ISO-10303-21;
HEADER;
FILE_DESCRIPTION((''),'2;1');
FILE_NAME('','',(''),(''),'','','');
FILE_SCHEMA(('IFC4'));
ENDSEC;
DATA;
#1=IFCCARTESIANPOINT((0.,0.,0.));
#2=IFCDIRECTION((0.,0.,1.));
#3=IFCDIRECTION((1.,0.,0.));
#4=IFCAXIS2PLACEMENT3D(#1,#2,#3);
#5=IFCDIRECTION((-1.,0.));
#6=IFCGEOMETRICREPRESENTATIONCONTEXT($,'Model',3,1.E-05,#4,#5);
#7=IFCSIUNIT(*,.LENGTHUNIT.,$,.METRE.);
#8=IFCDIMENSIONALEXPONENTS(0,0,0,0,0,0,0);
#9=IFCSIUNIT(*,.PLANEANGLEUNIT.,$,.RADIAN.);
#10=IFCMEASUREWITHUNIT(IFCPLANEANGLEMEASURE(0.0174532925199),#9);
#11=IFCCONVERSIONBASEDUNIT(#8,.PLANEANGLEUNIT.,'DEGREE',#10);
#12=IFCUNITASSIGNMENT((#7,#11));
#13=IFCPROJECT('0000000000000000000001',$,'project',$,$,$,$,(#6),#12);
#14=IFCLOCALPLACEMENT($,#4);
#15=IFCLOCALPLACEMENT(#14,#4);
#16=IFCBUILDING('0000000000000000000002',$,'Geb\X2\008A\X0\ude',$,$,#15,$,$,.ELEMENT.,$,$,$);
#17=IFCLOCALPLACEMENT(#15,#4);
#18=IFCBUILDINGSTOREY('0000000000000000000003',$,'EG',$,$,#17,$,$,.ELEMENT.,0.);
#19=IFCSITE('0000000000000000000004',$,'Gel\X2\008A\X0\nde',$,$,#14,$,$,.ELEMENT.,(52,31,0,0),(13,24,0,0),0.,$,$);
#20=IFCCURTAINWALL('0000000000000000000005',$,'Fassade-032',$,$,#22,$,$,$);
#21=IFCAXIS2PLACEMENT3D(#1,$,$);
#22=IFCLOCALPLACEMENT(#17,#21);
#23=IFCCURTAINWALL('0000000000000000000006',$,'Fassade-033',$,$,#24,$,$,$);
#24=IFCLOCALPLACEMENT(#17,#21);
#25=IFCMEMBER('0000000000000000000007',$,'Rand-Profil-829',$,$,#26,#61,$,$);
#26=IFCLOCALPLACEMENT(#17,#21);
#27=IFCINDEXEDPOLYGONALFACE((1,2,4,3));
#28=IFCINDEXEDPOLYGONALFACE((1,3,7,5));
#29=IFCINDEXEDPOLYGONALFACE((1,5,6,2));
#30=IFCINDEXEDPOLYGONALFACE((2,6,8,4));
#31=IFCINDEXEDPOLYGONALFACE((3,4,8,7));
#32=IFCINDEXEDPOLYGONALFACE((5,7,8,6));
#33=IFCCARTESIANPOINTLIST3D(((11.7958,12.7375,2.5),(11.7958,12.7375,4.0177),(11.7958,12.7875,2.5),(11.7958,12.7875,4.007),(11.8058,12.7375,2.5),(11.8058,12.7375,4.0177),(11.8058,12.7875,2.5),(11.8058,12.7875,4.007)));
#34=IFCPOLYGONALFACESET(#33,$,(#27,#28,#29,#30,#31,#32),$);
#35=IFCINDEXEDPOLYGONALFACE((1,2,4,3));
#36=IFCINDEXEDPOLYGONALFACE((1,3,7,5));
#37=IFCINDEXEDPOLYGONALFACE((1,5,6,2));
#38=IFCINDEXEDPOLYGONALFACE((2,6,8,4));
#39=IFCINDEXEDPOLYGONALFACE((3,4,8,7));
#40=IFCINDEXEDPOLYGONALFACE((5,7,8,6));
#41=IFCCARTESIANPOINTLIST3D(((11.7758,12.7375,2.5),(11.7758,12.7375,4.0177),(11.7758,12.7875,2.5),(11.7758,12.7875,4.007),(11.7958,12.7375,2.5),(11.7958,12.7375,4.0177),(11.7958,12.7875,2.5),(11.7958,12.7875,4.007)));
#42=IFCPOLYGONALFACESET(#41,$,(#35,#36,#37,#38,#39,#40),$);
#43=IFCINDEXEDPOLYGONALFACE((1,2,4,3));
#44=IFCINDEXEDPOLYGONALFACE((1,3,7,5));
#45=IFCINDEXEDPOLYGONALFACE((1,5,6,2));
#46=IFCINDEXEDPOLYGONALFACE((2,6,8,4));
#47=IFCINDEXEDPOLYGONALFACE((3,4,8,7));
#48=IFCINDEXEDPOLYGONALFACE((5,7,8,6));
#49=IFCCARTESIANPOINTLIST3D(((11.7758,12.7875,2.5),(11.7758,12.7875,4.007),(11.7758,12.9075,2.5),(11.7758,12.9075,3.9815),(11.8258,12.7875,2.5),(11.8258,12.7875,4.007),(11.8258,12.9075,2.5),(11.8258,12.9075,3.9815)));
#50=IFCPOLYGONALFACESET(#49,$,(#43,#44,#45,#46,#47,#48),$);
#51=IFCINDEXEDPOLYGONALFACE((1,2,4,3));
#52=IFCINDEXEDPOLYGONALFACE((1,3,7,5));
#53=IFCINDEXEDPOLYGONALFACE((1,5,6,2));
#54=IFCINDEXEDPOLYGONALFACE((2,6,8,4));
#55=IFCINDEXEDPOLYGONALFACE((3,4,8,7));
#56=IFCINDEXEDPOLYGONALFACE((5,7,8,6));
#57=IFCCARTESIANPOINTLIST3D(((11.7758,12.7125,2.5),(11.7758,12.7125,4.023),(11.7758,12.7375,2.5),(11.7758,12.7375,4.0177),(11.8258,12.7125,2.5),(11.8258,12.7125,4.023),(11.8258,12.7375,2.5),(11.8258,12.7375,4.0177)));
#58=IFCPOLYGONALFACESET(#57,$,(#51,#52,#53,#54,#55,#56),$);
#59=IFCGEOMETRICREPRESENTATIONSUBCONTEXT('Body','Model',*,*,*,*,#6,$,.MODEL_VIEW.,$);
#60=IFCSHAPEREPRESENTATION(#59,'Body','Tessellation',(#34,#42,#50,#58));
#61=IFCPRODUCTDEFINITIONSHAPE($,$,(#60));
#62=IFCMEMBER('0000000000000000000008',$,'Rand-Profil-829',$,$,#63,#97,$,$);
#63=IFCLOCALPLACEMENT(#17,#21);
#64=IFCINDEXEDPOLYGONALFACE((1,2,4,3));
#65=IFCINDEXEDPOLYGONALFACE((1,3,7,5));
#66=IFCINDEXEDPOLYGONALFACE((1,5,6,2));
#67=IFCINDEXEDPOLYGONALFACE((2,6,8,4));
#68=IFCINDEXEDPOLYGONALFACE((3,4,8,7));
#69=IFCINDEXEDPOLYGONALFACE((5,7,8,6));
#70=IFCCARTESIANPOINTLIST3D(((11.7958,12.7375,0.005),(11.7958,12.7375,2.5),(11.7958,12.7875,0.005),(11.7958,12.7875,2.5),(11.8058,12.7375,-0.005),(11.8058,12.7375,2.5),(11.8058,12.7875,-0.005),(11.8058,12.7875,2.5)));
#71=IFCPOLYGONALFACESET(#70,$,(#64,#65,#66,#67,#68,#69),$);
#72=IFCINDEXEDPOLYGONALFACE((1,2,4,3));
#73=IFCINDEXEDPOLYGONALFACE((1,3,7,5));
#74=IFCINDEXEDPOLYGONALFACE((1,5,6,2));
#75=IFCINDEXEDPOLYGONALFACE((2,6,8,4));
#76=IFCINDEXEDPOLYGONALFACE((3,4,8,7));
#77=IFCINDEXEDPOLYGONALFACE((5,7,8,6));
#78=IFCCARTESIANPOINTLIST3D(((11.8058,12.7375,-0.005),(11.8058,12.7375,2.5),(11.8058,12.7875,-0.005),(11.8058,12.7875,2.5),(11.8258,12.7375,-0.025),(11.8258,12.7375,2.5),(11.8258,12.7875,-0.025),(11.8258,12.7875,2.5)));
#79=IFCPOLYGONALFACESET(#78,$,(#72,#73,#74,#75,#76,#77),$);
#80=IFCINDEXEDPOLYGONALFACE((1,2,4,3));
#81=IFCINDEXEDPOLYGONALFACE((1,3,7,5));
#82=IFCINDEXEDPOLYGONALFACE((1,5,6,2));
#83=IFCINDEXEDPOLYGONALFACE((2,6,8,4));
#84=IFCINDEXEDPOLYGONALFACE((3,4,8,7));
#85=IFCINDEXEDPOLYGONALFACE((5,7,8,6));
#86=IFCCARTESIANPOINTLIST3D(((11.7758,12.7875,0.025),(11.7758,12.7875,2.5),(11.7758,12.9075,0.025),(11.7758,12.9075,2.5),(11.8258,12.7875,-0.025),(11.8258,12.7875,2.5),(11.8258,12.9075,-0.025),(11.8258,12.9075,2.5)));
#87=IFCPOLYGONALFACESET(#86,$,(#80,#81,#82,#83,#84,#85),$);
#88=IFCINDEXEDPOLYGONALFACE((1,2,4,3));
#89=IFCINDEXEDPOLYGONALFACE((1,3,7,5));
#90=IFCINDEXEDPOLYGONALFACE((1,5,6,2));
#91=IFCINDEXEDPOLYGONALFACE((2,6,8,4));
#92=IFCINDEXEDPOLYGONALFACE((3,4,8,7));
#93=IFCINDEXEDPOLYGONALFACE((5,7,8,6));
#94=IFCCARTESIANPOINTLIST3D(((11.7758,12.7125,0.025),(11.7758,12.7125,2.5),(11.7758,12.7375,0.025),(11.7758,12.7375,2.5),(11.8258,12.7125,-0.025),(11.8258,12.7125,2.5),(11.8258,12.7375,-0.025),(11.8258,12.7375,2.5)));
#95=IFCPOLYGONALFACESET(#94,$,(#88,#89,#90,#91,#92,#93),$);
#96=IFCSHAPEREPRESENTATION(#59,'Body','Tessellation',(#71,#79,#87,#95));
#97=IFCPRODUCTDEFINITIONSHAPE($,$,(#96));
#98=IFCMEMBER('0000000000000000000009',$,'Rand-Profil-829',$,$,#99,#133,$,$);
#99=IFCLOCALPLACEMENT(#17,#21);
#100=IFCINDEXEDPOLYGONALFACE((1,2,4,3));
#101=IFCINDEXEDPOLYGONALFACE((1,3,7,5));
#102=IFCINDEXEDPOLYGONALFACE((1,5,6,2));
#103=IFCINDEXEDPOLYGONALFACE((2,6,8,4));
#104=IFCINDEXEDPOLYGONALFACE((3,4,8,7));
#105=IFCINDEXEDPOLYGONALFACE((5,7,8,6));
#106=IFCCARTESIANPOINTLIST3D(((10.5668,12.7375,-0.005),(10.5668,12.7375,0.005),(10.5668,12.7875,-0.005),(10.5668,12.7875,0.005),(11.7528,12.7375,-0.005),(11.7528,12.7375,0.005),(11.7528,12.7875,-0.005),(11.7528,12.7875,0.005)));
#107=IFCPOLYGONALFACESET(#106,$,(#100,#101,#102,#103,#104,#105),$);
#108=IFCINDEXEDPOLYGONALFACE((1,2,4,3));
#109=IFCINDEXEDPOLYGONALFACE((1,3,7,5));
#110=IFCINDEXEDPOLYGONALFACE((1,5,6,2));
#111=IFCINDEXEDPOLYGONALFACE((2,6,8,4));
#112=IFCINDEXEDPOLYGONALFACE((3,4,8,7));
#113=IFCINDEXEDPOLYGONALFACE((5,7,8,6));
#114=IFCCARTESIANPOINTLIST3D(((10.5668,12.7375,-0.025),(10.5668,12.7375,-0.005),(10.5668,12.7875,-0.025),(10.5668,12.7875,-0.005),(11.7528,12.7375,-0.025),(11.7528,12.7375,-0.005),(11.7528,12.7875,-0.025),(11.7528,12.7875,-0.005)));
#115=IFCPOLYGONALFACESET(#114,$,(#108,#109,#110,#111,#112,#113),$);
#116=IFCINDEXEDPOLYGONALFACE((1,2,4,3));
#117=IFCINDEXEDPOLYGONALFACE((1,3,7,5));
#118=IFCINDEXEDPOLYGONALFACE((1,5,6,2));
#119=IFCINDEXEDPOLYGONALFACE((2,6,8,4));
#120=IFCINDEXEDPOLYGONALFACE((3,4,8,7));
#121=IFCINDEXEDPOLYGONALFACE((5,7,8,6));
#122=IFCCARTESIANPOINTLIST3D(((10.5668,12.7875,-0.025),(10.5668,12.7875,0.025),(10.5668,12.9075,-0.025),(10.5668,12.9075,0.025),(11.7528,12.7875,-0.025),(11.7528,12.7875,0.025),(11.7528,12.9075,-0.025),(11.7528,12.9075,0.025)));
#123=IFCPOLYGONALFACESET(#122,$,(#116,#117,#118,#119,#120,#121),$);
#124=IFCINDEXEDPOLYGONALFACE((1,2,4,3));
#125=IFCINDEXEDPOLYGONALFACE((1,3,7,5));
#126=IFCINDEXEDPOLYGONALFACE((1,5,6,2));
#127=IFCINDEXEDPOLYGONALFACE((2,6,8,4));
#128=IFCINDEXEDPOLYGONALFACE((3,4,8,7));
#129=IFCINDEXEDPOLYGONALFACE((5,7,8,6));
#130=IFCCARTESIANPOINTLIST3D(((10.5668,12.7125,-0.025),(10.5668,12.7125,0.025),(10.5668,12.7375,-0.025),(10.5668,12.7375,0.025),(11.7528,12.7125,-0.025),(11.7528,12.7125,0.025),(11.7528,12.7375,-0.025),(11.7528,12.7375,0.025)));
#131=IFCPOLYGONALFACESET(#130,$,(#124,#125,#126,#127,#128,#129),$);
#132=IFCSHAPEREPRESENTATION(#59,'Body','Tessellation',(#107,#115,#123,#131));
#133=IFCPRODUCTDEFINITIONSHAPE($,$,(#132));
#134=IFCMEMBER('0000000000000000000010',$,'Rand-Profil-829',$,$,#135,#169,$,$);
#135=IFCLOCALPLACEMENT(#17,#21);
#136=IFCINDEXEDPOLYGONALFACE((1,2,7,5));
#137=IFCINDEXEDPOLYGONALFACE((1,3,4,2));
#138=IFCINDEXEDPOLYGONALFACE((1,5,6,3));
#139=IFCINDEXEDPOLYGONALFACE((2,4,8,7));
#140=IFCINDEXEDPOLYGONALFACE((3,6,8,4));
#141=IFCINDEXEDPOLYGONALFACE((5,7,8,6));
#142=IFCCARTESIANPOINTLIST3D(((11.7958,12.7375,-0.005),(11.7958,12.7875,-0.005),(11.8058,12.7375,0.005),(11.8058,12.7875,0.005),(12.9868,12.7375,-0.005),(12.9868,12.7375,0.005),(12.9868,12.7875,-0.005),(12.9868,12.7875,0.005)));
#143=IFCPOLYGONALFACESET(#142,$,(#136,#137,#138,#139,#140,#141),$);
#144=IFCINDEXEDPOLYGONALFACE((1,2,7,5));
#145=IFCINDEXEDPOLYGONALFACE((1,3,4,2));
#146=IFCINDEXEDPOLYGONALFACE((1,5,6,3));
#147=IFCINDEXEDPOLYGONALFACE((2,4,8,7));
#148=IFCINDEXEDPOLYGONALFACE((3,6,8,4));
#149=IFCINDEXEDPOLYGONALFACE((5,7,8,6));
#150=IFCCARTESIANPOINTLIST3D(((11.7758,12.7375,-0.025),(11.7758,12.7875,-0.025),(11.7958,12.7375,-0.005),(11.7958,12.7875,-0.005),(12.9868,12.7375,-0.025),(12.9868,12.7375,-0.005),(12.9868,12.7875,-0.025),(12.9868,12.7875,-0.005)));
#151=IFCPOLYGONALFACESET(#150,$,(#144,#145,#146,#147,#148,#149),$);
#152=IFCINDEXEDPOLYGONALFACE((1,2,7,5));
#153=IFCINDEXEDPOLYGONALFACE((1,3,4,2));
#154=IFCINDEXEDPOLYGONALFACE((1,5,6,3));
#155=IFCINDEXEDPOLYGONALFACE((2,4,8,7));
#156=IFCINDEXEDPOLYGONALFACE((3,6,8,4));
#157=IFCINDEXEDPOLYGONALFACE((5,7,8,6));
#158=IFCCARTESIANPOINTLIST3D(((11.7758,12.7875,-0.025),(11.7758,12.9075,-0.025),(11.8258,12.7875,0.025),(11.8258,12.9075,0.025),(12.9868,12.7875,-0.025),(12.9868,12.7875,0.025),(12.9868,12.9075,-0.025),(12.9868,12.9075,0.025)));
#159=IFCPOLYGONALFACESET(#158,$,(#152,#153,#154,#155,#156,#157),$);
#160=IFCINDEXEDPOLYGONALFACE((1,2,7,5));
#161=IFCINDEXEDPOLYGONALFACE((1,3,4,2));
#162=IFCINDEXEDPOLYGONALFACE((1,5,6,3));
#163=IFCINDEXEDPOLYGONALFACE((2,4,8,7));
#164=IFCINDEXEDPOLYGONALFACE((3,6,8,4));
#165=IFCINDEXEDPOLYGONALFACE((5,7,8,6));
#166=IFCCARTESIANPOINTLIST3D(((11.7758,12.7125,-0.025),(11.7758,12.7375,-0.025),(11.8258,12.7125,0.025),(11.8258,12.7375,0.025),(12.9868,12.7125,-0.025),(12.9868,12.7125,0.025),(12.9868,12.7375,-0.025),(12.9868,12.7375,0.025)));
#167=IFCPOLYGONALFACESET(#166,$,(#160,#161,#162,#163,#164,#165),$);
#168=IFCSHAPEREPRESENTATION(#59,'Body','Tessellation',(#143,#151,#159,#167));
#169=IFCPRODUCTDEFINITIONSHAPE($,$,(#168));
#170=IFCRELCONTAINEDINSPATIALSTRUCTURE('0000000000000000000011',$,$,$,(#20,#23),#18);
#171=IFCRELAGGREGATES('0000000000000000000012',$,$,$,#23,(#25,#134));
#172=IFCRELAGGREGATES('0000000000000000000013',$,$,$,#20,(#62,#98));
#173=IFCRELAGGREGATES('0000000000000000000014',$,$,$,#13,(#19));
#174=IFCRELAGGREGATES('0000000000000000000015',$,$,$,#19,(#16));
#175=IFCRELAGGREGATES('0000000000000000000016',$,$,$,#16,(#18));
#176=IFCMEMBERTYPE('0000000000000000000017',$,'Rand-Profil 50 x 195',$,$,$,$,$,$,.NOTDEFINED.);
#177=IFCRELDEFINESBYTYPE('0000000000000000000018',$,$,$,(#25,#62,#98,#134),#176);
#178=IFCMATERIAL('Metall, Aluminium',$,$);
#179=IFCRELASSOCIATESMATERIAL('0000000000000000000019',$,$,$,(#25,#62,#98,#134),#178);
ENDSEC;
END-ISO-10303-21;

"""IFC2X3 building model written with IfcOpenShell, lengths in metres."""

from ifc_helpers import new_model, entity, si_unit, converted_unit, direction, frame, origin_with_axes, place, context, subcontext, project, spatial, polyline, outline, extrude, clip, halfspace, material, type_object, element, aggregate, save


model = new_model("IFC2X3")

# Units and contexts
model_context = context("Model", 3, precision=1e-05, world=origin_with_axes(), true_north=direction((-1.0, 0.0)))
body_context = subcontext(model_context, "Body", "Model", "MODEL_VIEW")
ifc_project = project(units=[si_unit("LENGTHUNIT", "METRE"), converted_unit("PLANEANGLEUNIT", "DEGREE", entity("IfcPlaneAngleMeasure", 0.0174532925199), si_unit("PLANEANGLEUNIT", "RADIAN"), dimensions=[0, 0, 0, 0, 0, 0, 0])], contexts=[model_context])

# Site, building, storey
site_placement = place(None, origin_with_axes())
site = spatial("IfcSite", under=ifc_project, at=site_placement, Name="Gel\u008ande", CompositionType="ELEMENT", RefLatitude=(52, 31, 0, 0), RefLongitude=(13, 24, 0, 0), RefElevation=0.0)
building_placement = place(site_placement, origin_with_axes())
building = spatial("IfcBuilding", under=site, at=building_placement, Name="Geb\u008aude", CompositionType="ELEMENT")
storey_placement = place(building_placement, origin_with_axes())
storey = spatial("IfcBuildingStorey", under=building, at=storey_placement, Name="EG", CompositionType="ELEMENT", Elevation=0.0)

# Curtain wall
curtain_wall_1_placement = place(storey_placement, frame((9.9738, 12.7625, 0.0), z_axis=(0.0, 0.0, 1.0), x_axis=(1.0, 0.0, 0.0)))
curtain_wall_1 = element("IfcCurtainWall", 1, at=curtain_wall_1_placement, inside=storey, Name="Fassade-032")
ifc_material = material(Name="Metall, Aluminium")

# Curtain wall
curtain_wall_2_placement = place(storey_placement, frame((12.3938, 12.7625, 0.0), z_axis=(0.0, 0.0, 1.0), x_axis=(1.0, 0.0, 0.0)))
curtain_wall_2 = element("IfcCurtainWall", 2, at=curtain_wall_2_placement, inside=storey, Name="Fassade-033")

# Members
member_type_1 = type_object("IfcMemberType", Name="Rand-Profil 50 x 195", PredefinedType="NOTDEFINED")
member_1_placement = place(curtain_wall_2_placement, frame((-0.593, 0.0, 2.5), z_axis=(0.0, 0.0, 1.0), x_axis=(-1.0, 0.0, 0.0)))
member_1 = element("IfcMember", 3, at=member_1_placement, type_object=member_type_1, material=ifc_material, Name="Rand-Profil-829", context=body_context, shape_type="Clipping", body=[
    clip(extrude(outline(polyline([(0.005, 0.025), (-0.005, 0.025), (-0.005, -0.025), (0.005, -0.025), (0.005, 0.025)])), frame((0.0, 0.0, 0.0), z_axis=(0.0, 0.0, 1.0), x_axis=(-1.0, 0.0, 0.0)), (0.0, 0.0, 1.0), 1.5177), halfspace(frame((0.0, -0.3076, 1.447), z_axis=(0.0, 0.207912, -0.978148), x_axis=(0.0, -0.978148, -0.207912)), True)),
    clip(extrude(outline(polyline([(-0.005, 0.025), (-0.025, 0.025), (-0.025, -0.025), (-0.005, -0.025), (-0.005, 0.025)])), frame((0.0, 0.0, 0.0), z_axis=(0.0, 0.0, 1.0), x_axis=(-1.0, 0.0, 0.0)), (0.0, 0.0, 1.0), 1.5177), halfspace(frame((0.0, -0.3076, 1.447), z_axis=(0.0, 0.207912, -0.978148), x_axis=(0.0, -0.978148, -0.207912)), True)),
    clip(extrude(outline(polyline([(0.025, 0.145), (-0.025, 0.145), (-0.025, 0.025), (0.025, 0.025), (0.025, 0.145)])), frame((0.0, 0.0, 0.0), z_axis=(0.0, 0.0, 1.0), x_axis=(-1.0, 0.0, 0.0)), (0.0, 0.0, 1.0), 1.507), halfspace(frame((0.0, -0.3076, 1.447), z_axis=(0.0, 0.207912, -0.978148), x_axis=(0.0, -0.978148, -0.207912)), True)),
    clip(extrude(outline(polyline([(0.025, -0.025), (-0.025, -0.025), (-0.025, -0.05), (0.025, -0.05), (0.025, -0.025)])), frame((0.0, 0.0, 0.0), z_axis=(0.0, 0.0, 1.0), x_axis=(-1.0, 0.0, 0.0)), (0.0, 0.0, 1.0), 1.523), halfspace(frame((0.0, -0.3076, 1.447), z_axis=(0.0, 0.207912, -0.978148), x_axis=(0.0, -0.978148, -0.207912)), True)),
])
member_2_placement = place(curtain_wall_1_placement, frame((1.827, 0.0, 0.0), z_axis=(0.0, 0.0, 1.0), x_axis=(-1.0, 0.0, 0.0)))
member_2 = element("IfcMember", 4, at=member_2_placement, type_object=member_type_1, material=ifc_material, Name="Rand-Profil-829", context=body_context, shape_type="Clipping", body=[
    clip(extrude(outline(polyline([(-0.005, 0.025), (-0.005, -0.025), (0.005, -0.025), (0.005, 0.025), (-0.005, 0.025)])), frame((0.0, 0.0, -0.005), z_axis=(0.0, 0.0, 1.0), x_axis=(-1.0, 0.0, 0.0)), (0.0, 0.0, 1.0), 2.505), halfspace(frame((0.0, 0.0, 0.0), z_axis=(-0.707107, 0.0, 0.707107), x_axis=(-0.707107, 0.0, -0.707107)), True)),
    clip(extrude(outline(polyline([(0.005, 0.025), (0.005, -0.025), (0.025, -0.025), (0.025, 0.025), (0.005, 0.025)])), frame((0.0, 0.0, -0.025), z_axis=(0.0, 0.0, 1.0), x_axis=(-1.0, 0.0, 0.0)), (0.0, 0.0, 1.0), 2.525), halfspace(frame((0.0, 0.0, 0.0), z_axis=(-0.707107, 0.0, 0.707107), x_axis=(-0.707107, 0.0, -0.707107)), True)),
    clip(extrude(outline(polyline([(-0.025, 0.145), (-0.025, 0.025), (0.025, 0.025), (0.025, 0.145), (-0.025, 0.145)])), frame((0.0, 0.0, -0.025), z_axis=(0.0, 0.0, 1.0), x_axis=(-1.0, 0.0, 0.0)), (0.0, 0.0, 1.0), 2.525), halfspace(frame((0.0, 0.0, 0.0), z_axis=(-0.707107, 0.0, 0.707107), x_axis=(-0.707107, 0.0, -0.707107)), True)),
    clip(extrude(outline(polyline([(0.025, -0.05), (0.025, -0.025), (-0.025, -0.025), (-0.025, -0.05), (0.025, -0.05)])), frame((0.0, 0.0, -0.025), z_axis=(0.0, 0.0, 1.0), x_axis=(-1.0, 0.0, 0.0)), (0.0, 0.0, 1.0), 2.525), halfspace(frame((0.0, 0.0, 0.0), z_axis=(-0.707107, 0.0, 0.707107), x_axis=(-0.707107, 0.0, -0.707107)), True)),
])
member_3_placement = place(curtain_wall_1_placement, frame((0.593, 0.0, 0.0), z_axis=(1.0, 0.0, 0.0), x_axis=(0.0, 0.0, 1.0)))
member_3 = element("IfcMember", 5, at=member_3_placement, type_object=member_type_1, material=ifc_material, Name="Rand-Profil-829", context=body_context, shape_type="SweptSolid", body=[
    extrude(outline(polyline([(-0.025, -0.005), (0.025, -0.005), (0.025, 0.005), (-0.025, 0.005), (-0.025, -0.005)])), frame((0.0, 0.0, 0.0), z_axis=(0.0, 0.0, 1.0), x_axis=(0.0, 1.0, 0.0)), (0.0, 0.0, 1.0), 1.186),
    extrude(outline(polyline([(-0.025, 0.005), (0.025, 0.005), (0.025, 0.025), (-0.025, 0.025), (-0.025, 0.005)])), frame((0.0, 0.0, 0.0), z_axis=(0.0, 0.0, 1.0), x_axis=(0.0, 1.0, 0.0)), (0.0, 0.0, 1.0), 1.186),
    extrude(outline(polyline([(-0.145, -0.025), (-0.025, -0.025), (-0.025, 0.025), (-0.145, 0.025), (-0.145, -0.025)])), frame((0.0, 0.0, 0.0), z_axis=(0.0, 0.0, 1.0), x_axis=(0.0, 1.0, 0.0)), (0.0, 0.0, 1.0), 1.186),
    extrude(outline(polyline([(0.05, 0.025), (0.025, 0.025), (0.025, -0.025), (0.05, -0.025), (0.05, 0.025)])), frame((0.0, 0.0, 0.0), z_axis=(0.0, 0.0, 1.0), x_axis=(0.0, 1.0, 0.0)), (0.0, 0.0, 1.0), 1.186),
])
member_4_placement = place(curtain_wall_2_placement, frame((-0.593, 0.0, 0.0), z_axis=(1.0, 0.0, 0.0), x_axis=(0.0, 0.0, 1.0)))
member_4 = element("IfcMember", 6, at=member_4_placement, type_object=member_type_1, material=ifc_material, Name="Rand-Profil-829", context=body_context, shape_type="Clipping", body=[
    clip(extrude(outline(polyline([(-0.025, -0.005), (0.025, -0.005), (0.025, 0.005), (-0.025, 0.005), (-0.025, -0.005)])), frame((0.0, 0.0, -0.005), z_axis=(0.0, 0.0, 1.0), x_axis=(0.0, 1.0, 0.0)), (0.0, 0.0, 1.0), 1.191), halfspace(frame((0.0, 0.0, 0.0), z_axis=(-0.707107, 0.0, 0.707107), x_axis=(-0.707107, 0.0, -0.707107)), True)),
    clip(extrude(outline(polyline([(-0.025, 0.005), (0.025, 0.005), (0.025, 0.025), (-0.025, 0.025), (-0.025, 0.005)])), frame((0.0, 0.0, -0.025), z_axis=(0.0, 0.0, 1.0), x_axis=(0.0, 1.0, 0.0)), (0.0, 0.0, 1.0), 1.211), halfspace(frame((0.0, 0.0, 0.0), z_axis=(-0.707107, 0.0, 0.707107), x_axis=(-0.707107, 0.0, -0.707107)), True)),
    clip(extrude(outline(polyline([(-0.145, -0.025), (-0.025, -0.025), (-0.025, 0.025), (-0.145, 0.025), (-0.145, -0.025)])), frame((0.0, 0.0, -0.025), z_axis=(0.0, 0.0, 1.0), x_axis=(0.0, 1.0, 0.0)), (0.0, 0.0, 1.0), 1.211), halfspace(frame((0.0, 0.0, 0.0), z_axis=(-0.707107, 0.0, 0.707107), x_axis=(-0.707107, 0.0, -0.707107)), True)),
    clip(extrude(outline(polyline([(0.05, 0.025), (0.025, 0.025), (0.025, -0.025), (0.05, -0.025), (0.05, 0.025)])), frame((0.0, 0.0, -0.025), z_axis=(0.0, 0.0, 1.0), x_axis=(0.0, 1.0, 0.0)), (0.0, 0.0, 1.0), 1.211), halfspace(frame((0.0, 0.0, 0.0), z_axis=(-0.707107, 0.0, 0.707107), x_axis=(-0.707107, 0.0, -0.707107)), True)),
])

aggregate(curtain_wall_2, [member_1, member_4])
aggregate(curtain_wall_1, [member_2, member_3])

save(model, "model.ifc")
